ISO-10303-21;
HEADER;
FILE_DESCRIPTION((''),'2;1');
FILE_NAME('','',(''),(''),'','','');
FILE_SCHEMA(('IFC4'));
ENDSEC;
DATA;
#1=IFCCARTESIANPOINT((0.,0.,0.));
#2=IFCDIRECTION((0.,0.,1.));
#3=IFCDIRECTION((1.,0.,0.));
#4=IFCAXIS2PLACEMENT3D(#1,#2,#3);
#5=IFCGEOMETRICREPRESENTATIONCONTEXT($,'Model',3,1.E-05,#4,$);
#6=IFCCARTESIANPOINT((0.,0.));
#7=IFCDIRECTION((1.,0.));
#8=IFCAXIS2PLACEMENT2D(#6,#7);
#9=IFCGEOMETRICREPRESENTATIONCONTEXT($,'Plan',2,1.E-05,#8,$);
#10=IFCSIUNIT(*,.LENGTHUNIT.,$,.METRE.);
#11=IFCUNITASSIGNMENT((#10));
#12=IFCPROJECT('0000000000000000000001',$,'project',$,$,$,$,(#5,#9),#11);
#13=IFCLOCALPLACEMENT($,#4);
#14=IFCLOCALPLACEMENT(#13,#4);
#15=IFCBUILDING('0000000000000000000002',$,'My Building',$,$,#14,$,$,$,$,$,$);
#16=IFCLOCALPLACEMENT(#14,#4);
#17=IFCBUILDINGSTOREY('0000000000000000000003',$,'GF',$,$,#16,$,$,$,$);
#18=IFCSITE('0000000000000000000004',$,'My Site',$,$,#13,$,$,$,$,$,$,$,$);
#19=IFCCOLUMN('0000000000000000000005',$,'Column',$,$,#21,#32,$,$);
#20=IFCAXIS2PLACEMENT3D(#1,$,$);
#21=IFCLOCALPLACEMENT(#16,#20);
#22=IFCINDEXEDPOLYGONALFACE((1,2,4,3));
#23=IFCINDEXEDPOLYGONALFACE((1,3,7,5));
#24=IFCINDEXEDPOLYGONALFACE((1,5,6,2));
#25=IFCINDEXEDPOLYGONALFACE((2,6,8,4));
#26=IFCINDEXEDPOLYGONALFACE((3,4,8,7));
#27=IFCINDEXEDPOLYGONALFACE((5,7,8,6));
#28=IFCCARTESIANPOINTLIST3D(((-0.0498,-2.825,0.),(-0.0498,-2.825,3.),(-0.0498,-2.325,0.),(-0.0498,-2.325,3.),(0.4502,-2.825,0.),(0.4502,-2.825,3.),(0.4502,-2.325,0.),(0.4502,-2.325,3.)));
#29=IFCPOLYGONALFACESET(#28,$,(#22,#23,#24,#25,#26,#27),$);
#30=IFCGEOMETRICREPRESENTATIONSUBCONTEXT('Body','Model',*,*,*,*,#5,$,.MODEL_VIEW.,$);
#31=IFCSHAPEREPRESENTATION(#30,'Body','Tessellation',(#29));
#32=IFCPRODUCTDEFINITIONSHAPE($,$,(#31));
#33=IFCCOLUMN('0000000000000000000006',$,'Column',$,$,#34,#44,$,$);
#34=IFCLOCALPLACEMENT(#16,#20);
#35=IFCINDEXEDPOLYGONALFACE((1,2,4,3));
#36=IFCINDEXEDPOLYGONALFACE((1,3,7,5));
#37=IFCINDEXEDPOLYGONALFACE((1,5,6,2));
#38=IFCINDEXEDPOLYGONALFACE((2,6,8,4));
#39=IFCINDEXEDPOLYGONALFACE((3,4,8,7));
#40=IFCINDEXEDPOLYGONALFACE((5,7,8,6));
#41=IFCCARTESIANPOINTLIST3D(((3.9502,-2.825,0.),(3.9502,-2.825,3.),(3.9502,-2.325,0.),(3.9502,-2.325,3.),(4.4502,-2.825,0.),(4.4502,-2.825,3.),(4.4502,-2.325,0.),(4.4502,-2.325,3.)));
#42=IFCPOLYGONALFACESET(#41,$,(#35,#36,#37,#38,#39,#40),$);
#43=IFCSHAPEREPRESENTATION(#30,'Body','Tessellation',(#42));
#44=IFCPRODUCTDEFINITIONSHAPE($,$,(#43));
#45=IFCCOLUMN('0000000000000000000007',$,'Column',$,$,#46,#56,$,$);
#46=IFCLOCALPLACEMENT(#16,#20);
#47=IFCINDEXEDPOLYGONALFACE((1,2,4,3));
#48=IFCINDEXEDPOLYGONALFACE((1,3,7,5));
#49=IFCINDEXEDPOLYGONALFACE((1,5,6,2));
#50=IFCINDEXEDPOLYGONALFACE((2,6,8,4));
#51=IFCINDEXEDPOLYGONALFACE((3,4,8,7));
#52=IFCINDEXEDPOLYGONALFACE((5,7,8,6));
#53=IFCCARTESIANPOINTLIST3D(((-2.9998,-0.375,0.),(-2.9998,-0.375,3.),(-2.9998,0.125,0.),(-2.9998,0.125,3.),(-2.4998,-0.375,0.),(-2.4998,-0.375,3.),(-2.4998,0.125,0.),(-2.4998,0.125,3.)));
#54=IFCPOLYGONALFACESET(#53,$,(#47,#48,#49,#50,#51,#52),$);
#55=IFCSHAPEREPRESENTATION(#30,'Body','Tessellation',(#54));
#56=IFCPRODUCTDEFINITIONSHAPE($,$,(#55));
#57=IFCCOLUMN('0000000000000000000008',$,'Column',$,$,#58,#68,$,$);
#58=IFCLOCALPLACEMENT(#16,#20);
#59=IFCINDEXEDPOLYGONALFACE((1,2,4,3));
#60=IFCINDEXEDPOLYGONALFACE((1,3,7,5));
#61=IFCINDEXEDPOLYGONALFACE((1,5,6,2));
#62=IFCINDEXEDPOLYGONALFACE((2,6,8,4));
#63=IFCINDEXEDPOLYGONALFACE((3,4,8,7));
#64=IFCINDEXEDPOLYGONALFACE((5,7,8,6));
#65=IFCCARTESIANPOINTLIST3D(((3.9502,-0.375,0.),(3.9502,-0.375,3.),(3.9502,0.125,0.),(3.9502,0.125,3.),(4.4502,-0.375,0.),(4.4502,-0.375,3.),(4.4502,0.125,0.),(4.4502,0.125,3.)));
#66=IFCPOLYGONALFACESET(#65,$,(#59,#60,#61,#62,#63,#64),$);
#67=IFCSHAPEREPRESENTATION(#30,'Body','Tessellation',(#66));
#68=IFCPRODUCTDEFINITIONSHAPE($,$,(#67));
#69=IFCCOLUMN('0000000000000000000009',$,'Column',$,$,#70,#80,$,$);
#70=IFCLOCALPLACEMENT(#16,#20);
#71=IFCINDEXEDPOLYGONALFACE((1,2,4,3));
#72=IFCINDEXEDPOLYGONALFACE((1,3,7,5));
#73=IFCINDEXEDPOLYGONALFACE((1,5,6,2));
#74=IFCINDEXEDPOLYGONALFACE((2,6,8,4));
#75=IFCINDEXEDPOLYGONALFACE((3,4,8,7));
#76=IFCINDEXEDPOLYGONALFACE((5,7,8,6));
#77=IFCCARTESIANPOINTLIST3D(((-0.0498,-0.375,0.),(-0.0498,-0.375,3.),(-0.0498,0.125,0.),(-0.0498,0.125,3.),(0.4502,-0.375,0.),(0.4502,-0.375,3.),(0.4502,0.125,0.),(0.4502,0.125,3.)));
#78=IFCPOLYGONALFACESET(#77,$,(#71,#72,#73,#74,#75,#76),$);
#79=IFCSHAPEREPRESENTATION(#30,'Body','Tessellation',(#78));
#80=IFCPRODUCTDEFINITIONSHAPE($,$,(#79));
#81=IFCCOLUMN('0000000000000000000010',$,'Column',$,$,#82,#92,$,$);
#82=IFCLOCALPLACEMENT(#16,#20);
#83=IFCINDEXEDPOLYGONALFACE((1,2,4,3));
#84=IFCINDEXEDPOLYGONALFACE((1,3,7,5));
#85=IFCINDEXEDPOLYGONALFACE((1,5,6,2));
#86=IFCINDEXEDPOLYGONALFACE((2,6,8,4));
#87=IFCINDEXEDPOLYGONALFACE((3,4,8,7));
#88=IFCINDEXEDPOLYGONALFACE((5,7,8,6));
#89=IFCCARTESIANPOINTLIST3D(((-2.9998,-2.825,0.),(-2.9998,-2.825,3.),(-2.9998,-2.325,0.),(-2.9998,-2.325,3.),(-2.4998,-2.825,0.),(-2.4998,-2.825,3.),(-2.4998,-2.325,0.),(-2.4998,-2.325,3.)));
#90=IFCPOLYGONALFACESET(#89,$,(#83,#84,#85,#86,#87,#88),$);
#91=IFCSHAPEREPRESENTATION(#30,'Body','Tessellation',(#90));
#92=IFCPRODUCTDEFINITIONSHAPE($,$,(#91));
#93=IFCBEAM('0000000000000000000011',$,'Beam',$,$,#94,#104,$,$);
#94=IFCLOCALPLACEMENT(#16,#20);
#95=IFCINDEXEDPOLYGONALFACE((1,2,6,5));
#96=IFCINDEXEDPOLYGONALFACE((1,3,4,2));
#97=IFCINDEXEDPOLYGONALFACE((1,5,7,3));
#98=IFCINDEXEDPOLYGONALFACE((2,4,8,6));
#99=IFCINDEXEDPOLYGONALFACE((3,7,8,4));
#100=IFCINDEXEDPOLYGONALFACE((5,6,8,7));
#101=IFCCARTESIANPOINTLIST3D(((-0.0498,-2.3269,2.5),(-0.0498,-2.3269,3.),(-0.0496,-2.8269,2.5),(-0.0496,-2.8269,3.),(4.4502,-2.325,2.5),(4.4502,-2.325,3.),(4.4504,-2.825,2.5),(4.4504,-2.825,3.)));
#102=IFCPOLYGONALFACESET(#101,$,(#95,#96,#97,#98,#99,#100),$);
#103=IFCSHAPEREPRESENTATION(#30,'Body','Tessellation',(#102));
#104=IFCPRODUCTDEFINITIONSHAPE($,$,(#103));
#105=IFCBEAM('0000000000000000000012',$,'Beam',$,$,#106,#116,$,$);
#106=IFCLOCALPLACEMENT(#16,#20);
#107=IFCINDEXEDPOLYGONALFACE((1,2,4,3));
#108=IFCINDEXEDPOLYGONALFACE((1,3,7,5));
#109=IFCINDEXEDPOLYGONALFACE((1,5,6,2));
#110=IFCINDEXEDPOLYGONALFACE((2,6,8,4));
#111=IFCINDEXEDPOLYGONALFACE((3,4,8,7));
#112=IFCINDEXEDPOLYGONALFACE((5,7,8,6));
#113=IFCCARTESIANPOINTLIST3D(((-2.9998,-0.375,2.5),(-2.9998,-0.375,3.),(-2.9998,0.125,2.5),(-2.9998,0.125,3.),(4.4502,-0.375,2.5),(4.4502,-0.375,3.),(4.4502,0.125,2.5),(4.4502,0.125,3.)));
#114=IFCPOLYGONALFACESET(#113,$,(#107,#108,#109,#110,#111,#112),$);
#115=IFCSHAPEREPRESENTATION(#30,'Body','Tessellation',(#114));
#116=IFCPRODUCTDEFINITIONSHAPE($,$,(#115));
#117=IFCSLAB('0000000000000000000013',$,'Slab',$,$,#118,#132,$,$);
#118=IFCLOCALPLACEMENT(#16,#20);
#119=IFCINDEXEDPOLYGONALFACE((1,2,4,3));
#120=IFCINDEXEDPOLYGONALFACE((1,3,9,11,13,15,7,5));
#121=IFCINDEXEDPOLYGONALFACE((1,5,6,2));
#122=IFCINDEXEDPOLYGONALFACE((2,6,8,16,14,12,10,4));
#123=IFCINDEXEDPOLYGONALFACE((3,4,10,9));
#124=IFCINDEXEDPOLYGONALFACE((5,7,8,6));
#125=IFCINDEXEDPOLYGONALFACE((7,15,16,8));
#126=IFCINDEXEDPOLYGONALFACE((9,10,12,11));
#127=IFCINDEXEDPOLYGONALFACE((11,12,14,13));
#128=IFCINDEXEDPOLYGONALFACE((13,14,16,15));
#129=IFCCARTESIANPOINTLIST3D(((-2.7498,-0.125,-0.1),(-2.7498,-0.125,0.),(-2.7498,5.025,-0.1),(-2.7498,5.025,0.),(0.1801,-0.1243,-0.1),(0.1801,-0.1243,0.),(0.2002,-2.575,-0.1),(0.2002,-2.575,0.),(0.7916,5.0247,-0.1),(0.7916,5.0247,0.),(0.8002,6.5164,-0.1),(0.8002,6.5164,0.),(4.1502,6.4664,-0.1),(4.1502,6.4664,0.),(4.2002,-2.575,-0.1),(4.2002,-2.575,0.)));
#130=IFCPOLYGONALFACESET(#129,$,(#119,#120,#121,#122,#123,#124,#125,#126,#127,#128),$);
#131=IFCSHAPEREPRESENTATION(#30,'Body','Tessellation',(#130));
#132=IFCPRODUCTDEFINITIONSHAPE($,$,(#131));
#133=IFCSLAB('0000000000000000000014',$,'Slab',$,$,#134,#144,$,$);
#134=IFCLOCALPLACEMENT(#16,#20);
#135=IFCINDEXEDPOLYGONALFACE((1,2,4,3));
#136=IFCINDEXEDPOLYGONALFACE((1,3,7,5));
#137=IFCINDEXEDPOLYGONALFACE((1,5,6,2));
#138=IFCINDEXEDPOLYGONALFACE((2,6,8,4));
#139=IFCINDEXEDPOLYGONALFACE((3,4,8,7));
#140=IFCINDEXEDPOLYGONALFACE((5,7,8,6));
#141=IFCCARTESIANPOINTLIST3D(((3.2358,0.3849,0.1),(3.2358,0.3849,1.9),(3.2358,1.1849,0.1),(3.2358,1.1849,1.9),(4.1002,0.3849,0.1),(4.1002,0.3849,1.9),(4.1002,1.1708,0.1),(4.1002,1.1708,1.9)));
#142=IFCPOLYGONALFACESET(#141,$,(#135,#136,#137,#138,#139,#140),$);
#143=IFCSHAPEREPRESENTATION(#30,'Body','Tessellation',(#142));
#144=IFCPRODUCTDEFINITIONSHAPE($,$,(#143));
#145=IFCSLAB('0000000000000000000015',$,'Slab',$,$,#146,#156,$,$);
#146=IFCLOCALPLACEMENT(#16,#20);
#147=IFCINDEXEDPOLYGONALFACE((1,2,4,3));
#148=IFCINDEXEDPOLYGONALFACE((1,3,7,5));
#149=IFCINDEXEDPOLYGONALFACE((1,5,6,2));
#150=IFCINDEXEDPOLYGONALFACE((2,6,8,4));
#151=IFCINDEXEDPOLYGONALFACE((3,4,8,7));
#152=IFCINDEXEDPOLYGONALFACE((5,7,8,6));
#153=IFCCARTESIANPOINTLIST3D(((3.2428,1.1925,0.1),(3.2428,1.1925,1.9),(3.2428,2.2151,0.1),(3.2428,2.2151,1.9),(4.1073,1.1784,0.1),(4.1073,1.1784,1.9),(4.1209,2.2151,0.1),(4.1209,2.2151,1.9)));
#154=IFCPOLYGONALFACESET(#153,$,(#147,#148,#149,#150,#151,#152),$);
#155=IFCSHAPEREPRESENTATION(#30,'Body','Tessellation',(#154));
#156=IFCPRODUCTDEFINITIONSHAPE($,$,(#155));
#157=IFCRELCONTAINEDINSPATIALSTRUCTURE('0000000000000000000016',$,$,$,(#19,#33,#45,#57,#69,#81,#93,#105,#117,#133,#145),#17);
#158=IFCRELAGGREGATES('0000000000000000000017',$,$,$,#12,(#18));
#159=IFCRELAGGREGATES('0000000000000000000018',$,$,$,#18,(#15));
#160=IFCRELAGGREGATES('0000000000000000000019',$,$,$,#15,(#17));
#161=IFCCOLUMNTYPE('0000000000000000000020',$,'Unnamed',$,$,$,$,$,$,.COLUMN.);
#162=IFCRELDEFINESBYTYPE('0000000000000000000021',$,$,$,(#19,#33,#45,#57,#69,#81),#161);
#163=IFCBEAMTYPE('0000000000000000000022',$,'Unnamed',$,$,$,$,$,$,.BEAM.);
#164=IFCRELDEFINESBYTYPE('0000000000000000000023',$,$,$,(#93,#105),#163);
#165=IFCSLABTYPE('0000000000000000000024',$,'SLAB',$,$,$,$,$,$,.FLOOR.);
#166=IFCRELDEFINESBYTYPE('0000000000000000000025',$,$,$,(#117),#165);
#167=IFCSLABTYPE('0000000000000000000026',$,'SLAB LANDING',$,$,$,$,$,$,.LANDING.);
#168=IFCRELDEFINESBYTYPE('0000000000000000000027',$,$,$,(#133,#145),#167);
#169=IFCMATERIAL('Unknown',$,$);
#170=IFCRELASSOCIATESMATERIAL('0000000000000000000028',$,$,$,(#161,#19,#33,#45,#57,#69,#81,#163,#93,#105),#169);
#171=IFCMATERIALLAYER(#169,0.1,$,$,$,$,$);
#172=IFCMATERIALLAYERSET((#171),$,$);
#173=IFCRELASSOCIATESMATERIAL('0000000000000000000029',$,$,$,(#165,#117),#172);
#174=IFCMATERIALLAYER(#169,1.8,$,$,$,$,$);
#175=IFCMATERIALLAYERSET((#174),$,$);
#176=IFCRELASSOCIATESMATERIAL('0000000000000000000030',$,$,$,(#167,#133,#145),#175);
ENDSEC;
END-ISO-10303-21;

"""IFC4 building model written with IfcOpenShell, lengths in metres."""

from ifc_helpers import new_model, si_unit, frame, origin_with_axes, origin_2d_with_axis, place, context, subcontext, project, spatial, indexed_curve, rectangle, outline, extrude, material, layer, layer_set, layer_usage, material_profile, profile_set, profile_usage, type_object, element, save


model = new_model("IFC4")

# Units and contexts
model_context = context("Model", 3, precision=1e-05, world=origin_with_axes())
plan_context = context("Plan", 2, precision=1e-05, world=origin_2d_with_axis())
body_context_1 = subcontext(model_context, "Body", "Model", "MODEL_VIEW")
ifc_project = project(units=[si_unit("LENGTHUNIT", "METRE")], contexts=[model_context, plan_context])

# Site, building, storey
site_placement = place(None, origin_with_axes())
site = spatial("IfcSite", under=ifc_project, at=site_placement, Name="My Site")
building_placement = place(site_placement, origin_with_axes())
building = spatial("IfcBuilding", under=site, at=building_placement, Name="My Building")
storey_placement = place(building_placement, origin_with_axes())
storey = spatial("IfcBuildingStorey", under=building, at=storey_placement, Name="GF")

# Columns
ifc_material = material(Name="Unknown")
ifc_material_profile_1 = material_profile(ifc_material, rectangle(XDim=0.5, YDim=0.5))
ifc_profile_set_1 = profile_set([ifc_material_profile_1])
ifc_profile_usage_1 = profile_usage(ifc_profile_set_1, cardinal=5)
column_type = type_object("IfcColumnType", Name="Unnamed", PredefinedType="COLUMN", material=ifc_profile_set_1)
column_1_placement = place(storey_placement, frame((0.2002, -2.575, 0.0), z_axis=(0.0, 0.0, 1.0), x_axis=(1.0, 0.0, 0.0)))
element("IfcColumn", 1, at=column_1_placement, inside=storey, type_object=column_type, material=ifc_profile_usage_1, Name="Column", context=body_context_1, shape_type="SweptSolid", body=[
    extrude(rectangle(XDim=0.5, YDim=0.5), origin_with_axes(), (0.0, 0.0, 1.0), 3.0),
])
ifc_profile_usage_2 = profile_usage(ifc_profile_set_1, cardinal=5)
column_2_placement = place(storey_placement, frame((4.2002, -2.575, 0.0), z_axis=(0.0, 0.0, 1.0), x_axis=(1.0, 0.0, 0.0)))
element("IfcColumn", 2, at=column_2_placement, inside=storey, type_object=column_type, material=ifc_profile_usage_2, Name="Column", context=body_context_1, shape_type="SweptSolid", body=[
    extrude(rectangle(XDim=0.5, YDim=0.5), origin_with_axes(), (0.0, 0.0, 1.0), 3.0),
])
ifc_profile_usage_3 = profile_usage(ifc_profile_set_1, cardinal=5)
column_3_placement = place(storey_placement, frame((-2.7498, -0.125, 0.0), z_axis=(0.0, 0.0, 1.0), x_axis=(1.0, 0.0, 0.0)))
element("IfcColumn", 3, at=column_3_placement, inside=storey, type_object=column_type, material=ifc_profile_usage_3, Name="Column", context=body_context_1, shape_type="SweptSolid", body=[
    extrude(rectangle(XDim=0.5, YDim=0.5), origin_with_axes(), (0.0, 0.0, 1.0), 3.0),
])
ifc_profile_usage_4 = profile_usage(ifc_profile_set_1, cardinal=5)
column_4_placement = place(storey_placement, frame((4.2002, -0.125, 0.0), z_axis=(0.0, 0.0, 1.0), x_axis=(1.0, 0.0, 0.0)))
element("IfcColumn", 4, at=column_4_placement, inside=storey, type_object=column_type, material=ifc_profile_usage_4, Name="Column", context=body_context_1, shape_type="SweptSolid", body=[
    extrude(rectangle(XDim=0.5, YDim=0.5), origin_with_axes(), (0.0, 0.0, 1.0), 3.0),
])
ifc_profile_usage_5 = profile_usage(ifc_profile_set_1, cardinal=5)
column_5_placement = place(storey_placement, frame((0.2002, -0.125, 0.0), z_axis=(0.0, 0.0, 1.0), x_axis=(1.0, 0.0, 0.0)))
element("IfcColumn", 5, at=column_5_placement, inside=storey, type_object=column_type, material=ifc_profile_usage_5, Name="Column", context=body_context_1, shape_type="SweptSolid", body=[
    extrude(rectangle(XDim=0.5, YDim=0.5), origin_with_axes(), (0.0, 0.0, 1.0), 3.0),
])
ifc_profile_usage_6 = profile_usage(ifc_profile_set_1, cardinal=5)
column_6_placement = place(storey_placement, frame((-2.7498, -2.575, 0.0), z_axis=(0.0, 0.0, 1.0), x_axis=(1.0, 0.0, 0.0)))
element("IfcColumn", 6, at=column_6_placement, inside=storey, type_object=column_type, material=ifc_profile_usage_6, Name="Column", context=body_context_1, shape_type="SweptSolid", body=[
    extrude(rectangle(XDim=0.5, YDim=0.5), origin_with_axes(), (0.0, 0.0, 1.0), 3.0),
])

# Beams
ifc_material_profile_2 = material_profile(ifc_material, rectangle(XDim=0.5, YDim=0.5))
ifc_profile_set_2 = profile_set([ifc_material_profile_2])
ifc_profile_usage_7 = profile_usage(ifc_profile_set_2, cardinal=7)
beam_type = type_object("IfcBeamType", Name="Unnamed", PredefinedType="BEAM", material=ifc_profile_set_2)
beam_1_placement = place(storey_placement, frame((-0.0498, -2.3269, 3.0), z_axis=(1.0, 0.000428, 0.0), x_axis=(-0.000428, 1.0, 0.0)))
element("IfcBeam", 7, at=beam_1_placement, inside=storey, type_object=beam_type, material=ifc_profile_usage_7, Name="Beam", context=body_context_1, shape_type="SweptSolid", body=[
    extrude(rectangle(XDim=0.5, YDim=0.5), frame((-0.25, -0.25, 0.0), z_axis=(0.0, 0.0, 1.0), x_axis=(1.0, 0.0, 0.0)), (0.0, 0.0, 1.0), 4.5),
])
ifc_profile_usage_8 = profile_usage(ifc_profile_set_2, cardinal=7)
beam_2_placement = place(storey_placement, frame((-2.9998, 0.125, 3.0), z_axis=(1.0, 0.0, 0.0), x_axis=(0.0, 1.0, 0.0)))
element("IfcBeam", 8, at=beam_2_placement, inside=storey, type_object=beam_type, material=ifc_profile_usage_8, Name="Beam", context=body_context_1, shape_type="SweptSolid", body=[
    extrude(rectangle(XDim=0.5, YDim=0.5), frame((-0.25, -0.25, 0.0), z_axis=(0.0, 0.0, 1.0), x_axis=(1.0, 0.0, 0.0)), (0.0, 0.0, 1.0), 7.45),
])

# Slabs
ifc_layer_1 = layer(ifc_material, 0.1)
ifc_layer_set_1 = layer_set([ifc_layer_1])
ifc_layer_usage_1 = layer_usage(ifc_layer_set_1, "AXIS3", "POSITIVE", -0.1)
slab_type_1 = type_object("IfcSlabType", Name="SLAB", PredefinedType="FLOOR", material=ifc_layer_set_1)
slab_1_placement = place(storey_placement, frame((0.2002, -2.575, 0.0), z_axis=(0.0, 0.0, 1.0), x_axis=(1.0, 0.0, 0.0)))
element("IfcSlab", 9, at=slab_1_placement, inside=storey, type_object=slab_type_1, material=ifc_layer_usage_1, Name="Slab", context=body_context_1, shape_type="SweptSolid", body=[
    extrude(outline(indexed_curve([(0.0, 0.0), (4.0, 0.0), (3.95, 9.0414), (0.6, 9.0914), (0.5914, 7.5997), (-2.95, 7.6), (-2.95, 2.45), (-0.0201, 2.4507), (0.0, 0.0)])), frame((0.0, 0.0, -0.1), z_axis=(0.0, 0.0, 1.0), x_axis=(1.0, 0.0, 0.0)), (0.0, 0.0, 1.0), 0.1),
])
ifc_layer_2 = layer(ifc_material, 1.8)
ifc_layer_set_2 = layer_set([ifc_layer_2])
ifc_layer_usage_2 = layer_usage(ifc_layer_set_2, "AXIS3", "POSITIVE", -0.1)
slab_type_2 = type_object("IfcSlabType", Name="SLAB LANDING", PredefinedType="LANDING", material=ifc_layer_set_2)
slab_2_placement = place(storey_placement, frame((3.2358, 1.1849, 0.2), z_axis=(0.0, 0.0, 1.0), x_axis=(1.0, 0.0, 0.0)))
element("IfcSlab", 10, at=slab_2_placement, inside=storey, type_object=slab_type_2, material=ifc_layer_usage_2, Name="Slab", context=body_context_1, shape_type="SweptSolid", body=[
    extrude(outline(indexed_curve([(0.0, 0.0), (0.0, -0.8), (0.8645, -0.8), (0.8645, -0.0141), (0.0, 0.0)])), frame((0.0, 0.0, -0.1), z_axis=(0.0, 0.0, 1.0), x_axis=(1.0, 0.0, 0.0)), (0.0, 0.0, 1.0), 1.8),
])
ifc_layer_usage_3 = layer_usage(ifc_layer_set_2, "AXIS3", "POSITIVE", -1.8)
slab_3_placement = place(storey_placement, frame((3.2428, 1.1925, 1.9), z_axis=(0.0, 0.0, 1.0), x_axis=(1.0, 0.0, 0.0)))
element("IfcSlab", 11, at=slab_3_placement, inside=storey, type_object=slab_type_2, material=ifc_layer_usage_3, Name="Slab", context=body_context_1, shape_type="SweptSolid", body=[
    extrude(outline(indexed_curve([(0.0, 0.0), (0.0, 1.0226), (0.8781, 1.0226), (0.8645, -0.0141), (0.0, 0.0)])), frame((0.0, 0.0, -1.8), z_axis=(0.0, 0.0, 1.0), x_axis=(1.0, 0.0, 0.0)), (0.0, 0.0, 1.0), 1.8),
])

save(model, "model.ifc")
